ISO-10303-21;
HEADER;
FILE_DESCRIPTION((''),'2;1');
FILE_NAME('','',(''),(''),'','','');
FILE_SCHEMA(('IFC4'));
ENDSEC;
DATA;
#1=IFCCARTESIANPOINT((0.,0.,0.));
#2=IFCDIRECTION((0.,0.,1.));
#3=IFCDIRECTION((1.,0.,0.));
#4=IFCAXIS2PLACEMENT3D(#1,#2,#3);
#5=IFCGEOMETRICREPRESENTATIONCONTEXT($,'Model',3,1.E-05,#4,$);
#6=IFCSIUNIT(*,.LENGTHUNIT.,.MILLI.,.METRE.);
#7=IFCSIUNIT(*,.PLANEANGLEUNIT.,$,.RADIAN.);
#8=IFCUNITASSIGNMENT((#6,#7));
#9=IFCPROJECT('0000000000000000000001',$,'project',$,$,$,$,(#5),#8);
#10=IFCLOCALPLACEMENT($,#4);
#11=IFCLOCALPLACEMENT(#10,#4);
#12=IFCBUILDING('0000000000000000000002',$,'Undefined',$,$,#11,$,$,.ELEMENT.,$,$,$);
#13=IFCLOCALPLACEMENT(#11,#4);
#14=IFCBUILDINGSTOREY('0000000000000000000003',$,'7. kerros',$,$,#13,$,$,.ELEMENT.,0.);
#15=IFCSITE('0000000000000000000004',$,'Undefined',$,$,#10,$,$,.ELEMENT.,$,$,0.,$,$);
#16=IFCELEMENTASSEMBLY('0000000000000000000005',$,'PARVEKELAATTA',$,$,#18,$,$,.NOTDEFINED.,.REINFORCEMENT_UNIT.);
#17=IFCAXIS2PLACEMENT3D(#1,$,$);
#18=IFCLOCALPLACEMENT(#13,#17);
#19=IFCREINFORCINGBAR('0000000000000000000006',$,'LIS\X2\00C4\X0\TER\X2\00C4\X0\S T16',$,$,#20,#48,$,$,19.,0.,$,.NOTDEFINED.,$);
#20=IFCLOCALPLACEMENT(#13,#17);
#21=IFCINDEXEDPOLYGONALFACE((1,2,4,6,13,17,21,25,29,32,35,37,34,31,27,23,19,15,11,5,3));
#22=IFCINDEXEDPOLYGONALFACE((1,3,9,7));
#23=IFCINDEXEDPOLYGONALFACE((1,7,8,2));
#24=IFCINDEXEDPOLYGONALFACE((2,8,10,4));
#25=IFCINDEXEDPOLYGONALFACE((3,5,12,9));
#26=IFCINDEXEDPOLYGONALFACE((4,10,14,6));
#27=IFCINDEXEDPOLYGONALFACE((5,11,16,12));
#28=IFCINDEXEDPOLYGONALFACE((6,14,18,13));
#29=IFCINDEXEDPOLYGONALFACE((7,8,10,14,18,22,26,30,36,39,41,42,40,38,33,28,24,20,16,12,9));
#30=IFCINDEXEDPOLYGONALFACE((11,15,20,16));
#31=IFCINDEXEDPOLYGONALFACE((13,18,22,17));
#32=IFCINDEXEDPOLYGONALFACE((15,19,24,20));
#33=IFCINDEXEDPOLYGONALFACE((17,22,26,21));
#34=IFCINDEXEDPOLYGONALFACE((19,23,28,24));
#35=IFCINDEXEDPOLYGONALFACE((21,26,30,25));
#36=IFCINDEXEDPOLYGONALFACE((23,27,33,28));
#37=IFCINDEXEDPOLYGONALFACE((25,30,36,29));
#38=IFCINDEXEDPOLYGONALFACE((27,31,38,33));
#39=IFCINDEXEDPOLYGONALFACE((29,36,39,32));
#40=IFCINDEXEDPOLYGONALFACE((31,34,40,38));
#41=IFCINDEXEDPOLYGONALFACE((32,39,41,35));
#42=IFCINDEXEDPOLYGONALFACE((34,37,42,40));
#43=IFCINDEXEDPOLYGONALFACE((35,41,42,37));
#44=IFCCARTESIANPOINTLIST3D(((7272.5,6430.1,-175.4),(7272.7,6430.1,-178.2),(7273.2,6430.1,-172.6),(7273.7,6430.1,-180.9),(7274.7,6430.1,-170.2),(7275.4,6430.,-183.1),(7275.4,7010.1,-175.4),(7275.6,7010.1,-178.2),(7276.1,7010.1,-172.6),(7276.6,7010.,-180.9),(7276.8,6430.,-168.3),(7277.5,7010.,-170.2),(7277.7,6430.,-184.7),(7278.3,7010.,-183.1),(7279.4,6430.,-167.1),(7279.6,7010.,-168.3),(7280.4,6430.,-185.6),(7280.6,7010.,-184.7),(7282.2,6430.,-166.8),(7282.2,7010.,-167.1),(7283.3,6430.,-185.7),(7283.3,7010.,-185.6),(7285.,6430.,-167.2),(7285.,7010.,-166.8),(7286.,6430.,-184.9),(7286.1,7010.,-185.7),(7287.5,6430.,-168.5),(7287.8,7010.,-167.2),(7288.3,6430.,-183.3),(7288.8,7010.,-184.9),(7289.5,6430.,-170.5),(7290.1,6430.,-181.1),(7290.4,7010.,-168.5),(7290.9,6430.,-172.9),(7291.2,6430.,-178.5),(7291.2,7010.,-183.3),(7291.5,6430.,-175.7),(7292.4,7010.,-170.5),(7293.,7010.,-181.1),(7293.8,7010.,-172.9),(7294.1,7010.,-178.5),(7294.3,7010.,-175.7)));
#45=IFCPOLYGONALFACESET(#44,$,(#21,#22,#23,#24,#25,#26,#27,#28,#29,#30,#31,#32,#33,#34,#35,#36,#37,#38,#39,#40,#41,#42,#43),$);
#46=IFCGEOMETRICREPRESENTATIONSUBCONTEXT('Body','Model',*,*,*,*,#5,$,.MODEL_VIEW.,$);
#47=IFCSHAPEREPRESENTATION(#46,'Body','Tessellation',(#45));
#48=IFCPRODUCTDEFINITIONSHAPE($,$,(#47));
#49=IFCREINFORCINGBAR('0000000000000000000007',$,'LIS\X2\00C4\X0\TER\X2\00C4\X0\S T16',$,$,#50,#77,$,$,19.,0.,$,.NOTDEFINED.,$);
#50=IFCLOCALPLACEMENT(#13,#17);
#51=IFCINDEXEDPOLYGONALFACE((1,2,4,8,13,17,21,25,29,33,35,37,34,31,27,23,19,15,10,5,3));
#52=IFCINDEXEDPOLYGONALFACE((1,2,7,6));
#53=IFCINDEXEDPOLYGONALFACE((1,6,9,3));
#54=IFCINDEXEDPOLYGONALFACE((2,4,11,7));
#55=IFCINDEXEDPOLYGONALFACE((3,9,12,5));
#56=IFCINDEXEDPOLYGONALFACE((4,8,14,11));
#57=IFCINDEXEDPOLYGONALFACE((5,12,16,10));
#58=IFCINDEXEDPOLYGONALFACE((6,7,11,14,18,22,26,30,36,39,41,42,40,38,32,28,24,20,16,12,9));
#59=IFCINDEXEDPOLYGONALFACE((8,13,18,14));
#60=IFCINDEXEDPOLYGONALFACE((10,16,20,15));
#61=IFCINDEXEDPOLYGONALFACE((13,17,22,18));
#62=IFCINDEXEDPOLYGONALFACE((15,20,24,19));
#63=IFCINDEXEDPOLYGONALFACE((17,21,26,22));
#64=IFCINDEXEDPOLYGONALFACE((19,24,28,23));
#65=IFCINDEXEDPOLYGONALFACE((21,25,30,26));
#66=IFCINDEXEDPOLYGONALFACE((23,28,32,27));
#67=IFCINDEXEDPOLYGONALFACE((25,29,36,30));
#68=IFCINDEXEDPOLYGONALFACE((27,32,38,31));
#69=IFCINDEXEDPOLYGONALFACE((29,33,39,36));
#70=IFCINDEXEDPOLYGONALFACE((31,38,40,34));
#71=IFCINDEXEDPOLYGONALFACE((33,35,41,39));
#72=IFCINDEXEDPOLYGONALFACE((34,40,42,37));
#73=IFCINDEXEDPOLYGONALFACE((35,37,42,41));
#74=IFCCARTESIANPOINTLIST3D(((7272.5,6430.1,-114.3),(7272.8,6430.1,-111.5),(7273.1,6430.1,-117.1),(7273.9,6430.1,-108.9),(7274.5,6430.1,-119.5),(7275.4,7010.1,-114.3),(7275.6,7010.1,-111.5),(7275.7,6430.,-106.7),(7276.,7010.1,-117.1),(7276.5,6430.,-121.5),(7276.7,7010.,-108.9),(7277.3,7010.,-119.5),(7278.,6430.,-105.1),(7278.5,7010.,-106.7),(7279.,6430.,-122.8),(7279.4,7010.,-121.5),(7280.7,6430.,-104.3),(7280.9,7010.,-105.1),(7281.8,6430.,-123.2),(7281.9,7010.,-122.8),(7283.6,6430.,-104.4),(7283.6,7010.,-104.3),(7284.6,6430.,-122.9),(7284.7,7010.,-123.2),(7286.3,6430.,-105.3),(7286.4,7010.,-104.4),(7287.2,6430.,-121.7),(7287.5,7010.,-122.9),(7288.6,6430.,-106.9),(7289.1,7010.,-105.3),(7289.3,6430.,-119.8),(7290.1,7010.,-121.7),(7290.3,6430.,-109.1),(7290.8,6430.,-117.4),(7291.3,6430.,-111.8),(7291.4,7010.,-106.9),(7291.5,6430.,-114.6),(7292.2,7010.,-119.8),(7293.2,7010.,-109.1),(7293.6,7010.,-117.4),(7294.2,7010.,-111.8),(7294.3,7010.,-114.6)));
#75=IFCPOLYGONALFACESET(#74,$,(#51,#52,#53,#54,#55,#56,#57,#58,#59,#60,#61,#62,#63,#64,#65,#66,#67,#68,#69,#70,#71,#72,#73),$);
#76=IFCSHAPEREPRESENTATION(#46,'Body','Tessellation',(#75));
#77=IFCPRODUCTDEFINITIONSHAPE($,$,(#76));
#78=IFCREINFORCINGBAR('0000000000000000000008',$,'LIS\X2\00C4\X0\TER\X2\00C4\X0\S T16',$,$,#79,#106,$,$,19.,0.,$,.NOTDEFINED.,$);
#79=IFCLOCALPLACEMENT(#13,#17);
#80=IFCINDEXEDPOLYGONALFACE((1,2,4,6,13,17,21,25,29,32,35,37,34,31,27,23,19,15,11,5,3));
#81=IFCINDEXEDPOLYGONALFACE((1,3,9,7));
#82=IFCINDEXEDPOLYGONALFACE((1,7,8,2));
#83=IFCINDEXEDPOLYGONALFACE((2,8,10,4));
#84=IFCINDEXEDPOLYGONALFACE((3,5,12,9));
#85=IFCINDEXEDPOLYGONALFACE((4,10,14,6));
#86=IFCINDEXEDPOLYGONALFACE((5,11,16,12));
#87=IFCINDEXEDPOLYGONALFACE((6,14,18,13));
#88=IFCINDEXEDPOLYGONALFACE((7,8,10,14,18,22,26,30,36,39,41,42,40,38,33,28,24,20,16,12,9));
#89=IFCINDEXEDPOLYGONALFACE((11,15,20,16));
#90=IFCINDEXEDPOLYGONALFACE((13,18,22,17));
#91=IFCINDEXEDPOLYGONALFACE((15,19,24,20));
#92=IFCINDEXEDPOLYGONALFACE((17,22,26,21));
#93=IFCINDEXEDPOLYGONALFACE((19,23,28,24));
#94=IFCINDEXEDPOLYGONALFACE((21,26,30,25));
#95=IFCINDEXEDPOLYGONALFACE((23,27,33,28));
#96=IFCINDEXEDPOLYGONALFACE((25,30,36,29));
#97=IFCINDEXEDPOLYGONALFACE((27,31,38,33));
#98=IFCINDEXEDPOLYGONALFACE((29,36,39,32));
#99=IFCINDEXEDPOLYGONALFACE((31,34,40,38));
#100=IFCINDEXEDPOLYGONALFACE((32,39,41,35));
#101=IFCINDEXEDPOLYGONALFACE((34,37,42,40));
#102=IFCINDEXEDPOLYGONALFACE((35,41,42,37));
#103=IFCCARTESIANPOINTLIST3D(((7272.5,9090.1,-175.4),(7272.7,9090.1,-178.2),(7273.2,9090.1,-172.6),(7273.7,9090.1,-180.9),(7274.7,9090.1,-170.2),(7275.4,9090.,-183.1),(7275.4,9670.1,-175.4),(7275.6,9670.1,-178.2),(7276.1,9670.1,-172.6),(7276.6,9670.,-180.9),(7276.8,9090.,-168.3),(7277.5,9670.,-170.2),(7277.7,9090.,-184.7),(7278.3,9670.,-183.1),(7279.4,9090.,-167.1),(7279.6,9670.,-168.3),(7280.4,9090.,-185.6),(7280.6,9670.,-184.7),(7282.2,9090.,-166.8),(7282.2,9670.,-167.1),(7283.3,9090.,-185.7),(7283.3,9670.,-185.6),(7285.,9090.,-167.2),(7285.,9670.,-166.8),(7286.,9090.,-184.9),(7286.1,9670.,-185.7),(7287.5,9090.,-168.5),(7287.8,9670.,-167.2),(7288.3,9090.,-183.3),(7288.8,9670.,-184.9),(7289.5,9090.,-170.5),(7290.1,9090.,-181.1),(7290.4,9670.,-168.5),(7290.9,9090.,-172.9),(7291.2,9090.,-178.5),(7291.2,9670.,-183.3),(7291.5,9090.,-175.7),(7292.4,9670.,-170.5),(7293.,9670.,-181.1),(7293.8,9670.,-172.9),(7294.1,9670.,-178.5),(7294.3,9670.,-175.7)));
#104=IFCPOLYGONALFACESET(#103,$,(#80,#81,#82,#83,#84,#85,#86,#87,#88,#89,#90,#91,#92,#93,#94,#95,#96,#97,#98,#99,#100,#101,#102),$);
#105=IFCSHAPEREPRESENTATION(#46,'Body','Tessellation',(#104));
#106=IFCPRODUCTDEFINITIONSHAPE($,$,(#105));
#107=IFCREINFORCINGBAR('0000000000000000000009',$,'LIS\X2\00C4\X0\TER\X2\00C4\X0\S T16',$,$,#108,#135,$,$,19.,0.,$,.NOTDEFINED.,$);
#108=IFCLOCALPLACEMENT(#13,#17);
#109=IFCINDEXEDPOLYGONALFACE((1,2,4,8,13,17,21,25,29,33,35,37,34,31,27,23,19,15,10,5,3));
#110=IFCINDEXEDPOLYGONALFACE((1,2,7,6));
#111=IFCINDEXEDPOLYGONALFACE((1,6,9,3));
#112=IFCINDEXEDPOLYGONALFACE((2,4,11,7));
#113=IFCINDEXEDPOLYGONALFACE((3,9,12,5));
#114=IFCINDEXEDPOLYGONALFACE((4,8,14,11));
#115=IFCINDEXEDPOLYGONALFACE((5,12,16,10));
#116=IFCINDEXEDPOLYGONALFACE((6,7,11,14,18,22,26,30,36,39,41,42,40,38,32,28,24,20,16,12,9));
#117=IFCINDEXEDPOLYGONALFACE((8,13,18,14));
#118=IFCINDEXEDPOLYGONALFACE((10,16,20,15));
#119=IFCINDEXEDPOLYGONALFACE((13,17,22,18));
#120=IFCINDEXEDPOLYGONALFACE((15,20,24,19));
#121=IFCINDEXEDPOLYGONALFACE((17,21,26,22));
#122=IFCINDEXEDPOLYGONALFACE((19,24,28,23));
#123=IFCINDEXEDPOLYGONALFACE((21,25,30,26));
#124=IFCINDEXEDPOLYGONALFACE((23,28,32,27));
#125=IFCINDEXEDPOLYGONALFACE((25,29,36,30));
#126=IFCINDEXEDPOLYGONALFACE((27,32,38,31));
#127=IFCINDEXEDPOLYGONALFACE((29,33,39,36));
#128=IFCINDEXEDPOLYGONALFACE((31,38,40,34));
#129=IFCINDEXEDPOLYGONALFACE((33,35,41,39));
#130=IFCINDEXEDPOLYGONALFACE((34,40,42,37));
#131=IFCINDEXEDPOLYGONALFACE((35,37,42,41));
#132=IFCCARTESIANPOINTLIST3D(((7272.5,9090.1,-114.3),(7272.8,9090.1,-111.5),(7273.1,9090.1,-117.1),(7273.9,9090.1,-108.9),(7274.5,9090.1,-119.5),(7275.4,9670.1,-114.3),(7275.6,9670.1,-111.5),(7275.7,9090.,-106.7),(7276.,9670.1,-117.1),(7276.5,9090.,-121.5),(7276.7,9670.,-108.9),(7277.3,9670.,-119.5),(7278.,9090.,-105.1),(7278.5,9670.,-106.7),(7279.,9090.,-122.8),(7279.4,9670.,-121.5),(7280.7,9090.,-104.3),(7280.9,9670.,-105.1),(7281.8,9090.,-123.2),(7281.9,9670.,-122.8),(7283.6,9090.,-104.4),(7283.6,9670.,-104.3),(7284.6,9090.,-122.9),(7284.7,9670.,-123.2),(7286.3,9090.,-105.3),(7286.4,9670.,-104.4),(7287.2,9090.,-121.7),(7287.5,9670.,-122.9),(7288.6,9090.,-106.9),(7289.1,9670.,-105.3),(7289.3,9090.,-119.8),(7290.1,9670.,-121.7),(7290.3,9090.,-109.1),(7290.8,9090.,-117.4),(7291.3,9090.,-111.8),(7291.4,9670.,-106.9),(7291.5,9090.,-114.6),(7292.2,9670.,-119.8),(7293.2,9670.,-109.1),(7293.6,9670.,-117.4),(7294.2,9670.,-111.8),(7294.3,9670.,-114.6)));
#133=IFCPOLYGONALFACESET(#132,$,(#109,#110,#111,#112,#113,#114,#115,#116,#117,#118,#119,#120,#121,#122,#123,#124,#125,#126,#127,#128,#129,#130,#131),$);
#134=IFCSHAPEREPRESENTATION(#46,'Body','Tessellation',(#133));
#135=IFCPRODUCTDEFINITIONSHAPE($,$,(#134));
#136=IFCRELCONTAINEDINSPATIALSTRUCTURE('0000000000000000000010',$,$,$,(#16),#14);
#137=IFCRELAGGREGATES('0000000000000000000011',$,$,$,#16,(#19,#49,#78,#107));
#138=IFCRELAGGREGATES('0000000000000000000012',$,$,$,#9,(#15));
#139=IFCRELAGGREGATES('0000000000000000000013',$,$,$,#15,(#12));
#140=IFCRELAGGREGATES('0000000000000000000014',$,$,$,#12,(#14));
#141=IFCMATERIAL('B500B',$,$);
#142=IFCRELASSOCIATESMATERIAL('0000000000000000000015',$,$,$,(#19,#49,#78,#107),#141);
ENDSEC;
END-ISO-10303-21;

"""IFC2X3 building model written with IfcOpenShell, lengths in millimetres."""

from ifc_helpers import new_model, entity, si_unit, frame, origin_with_axes, place, context, subcontext, project, spatial, source, transform, mapped, material, element, aggregate, save


model = new_model("IFC2X3")

# Units and contexts
model_context = context("Model", 3, precision=1e-05, world=origin_with_axes())
body_context = subcontext(model_context, "Body", "Model", "MODEL_VIEW")
ifc_project = project(units=[si_unit("LENGTHUNIT", "METRE", prefix="MILLI"), si_unit("PLANEANGLEUNIT", "RADIAN")], contexts=[model_context])

# Site, building, storey
site_placement = place(None, origin_with_axes())
site = spatial("IfcSite", under=ifc_project, at=site_placement, Name="Undefined", CompositionType="ELEMENT", RefElevation=0.0)
building_placement = place(site_placement, origin_with_axes())
building = spatial("IfcBuilding", under=site, at=building_placement, Name="Undefined", CompositionType="ELEMENT")
storey_placement = place(building_placement, origin_with_axes())
storey = spatial("IfcBuildingStorey", under=building, at=storey_placement, Name="7. kerros", CompositionType="ELEMENT", Elevation=0.0)

# Element assembly, reinforcing bars
assembly_placement = place(storey_placement, origin_with_axes())
assembly = element("IfcElementAssembly", 1, at=assembly_placement, inside=storey, Name="PARVEKELAATTA", AssemblyPlace="NOTDEFINED", PredefinedType="REINFORCEMENT_UNIT")
ifc_material_1 = material(Name="B500B")
shared_shape_1 = source(origin_with_axes(), body_context, "Body", "AdvancedSweptSolid", [
    entity("IfcSweptDiskSolid", entity("IfcTrimmedCurve", entity("IfcLine", entity("IfcCartesianPoint", [0.0, 0.0, 0.0]), entity("IfcVector", entity("IfcDirection", [1.0, 0.0, 0.0]), 1.0)), [entity("IfcParameterValue", 0.0)], [entity("IfcParameterValue", 580.0)], True, "PARAMETER"), 9.5, None, 0.0, 580.0),
])
reinforcing_bar_1_placement = place(assembly_placement, frame((7284.9, 7010.0, -176.2), z_axis=(0.857354, -0.004233, -0.51471), x_axis=(-0.004937, -0.999988, 0.0)))
reinforcing_bar_1 = element("IfcReinforcingBar", 2, at=reinforcing_bar_1_placement, material=ifc_material_1, Name="LISÄTERÄS T16", BarRole="NOTDEFINED", CrossSectionArea=0.0, NominalDiameter=19.0, context=body_context, shape_type="MappedRepresentation", body=[
    mapped(shared_shape_1, transform((0.0, 0.0, 0.0))),
])
shared_shape_2 = source(origin_with_axes(), body_context, "Body", "AdvancedSweptSolid", [
    entity("IfcSweptDiskSolid", entity("IfcTrimmedCurve", entity("IfcLine", entity("IfcCartesianPoint", [0.0, 0.0, 0.0]), entity("IfcVector", entity("IfcDirection", [1.0, 0.0, 0.0]), 1.0)), [entity("IfcParameterValue", 0.0)], [entity("IfcParameterValue", 580.0)], True, "PARAMETER"), 9.5, None, 0.0, 580.0),
])
reinforcing_bar_2_placement = place(assembly_placement, frame((7282.0, 6430.0, -113.7), z_axis=(-0.857354, 0.004233, 0.51471), x_axis=(0.004937, 0.999988, 0.0)))
reinforcing_bar_2 = element("IfcReinforcingBar", 3, at=reinforcing_bar_2_placement, material=ifc_material_1, Name="LISÄTERÄS T16", BarRole="NOTDEFINED", CrossSectionArea=0.0, NominalDiameter=19.0, context=body_context, shape_type="MappedRepresentation", body=[
    mapped(shared_shape_2, transform((0.0, 0.0, 0.0))),
])
shared_shape_3 = source(origin_with_axes(), body_context, "Body", "AdvancedSweptSolid", [
    entity("IfcSweptDiskSolid", entity("IfcTrimmedCurve", entity("IfcLine", entity("IfcCartesianPoint", [0.0, 0.0, 0.0]), entity("IfcVector", entity("IfcDirection", [1.0, 0.0, 0.0]), 1.0)), [entity("IfcParameterValue", 0.0)], [entity("IfcParameterValue", 580.0)], True, "PARAMETER"), 9.5, None, 0.0, 580.0),
])
reinforcing_bar_3_placement = place(assembly_placement, frame((7284.9, 9670.0, -176.2), z_axis=(0.857354, -0.004233, -0.51471), x_axis=(-0.004937, -0.999988, 0.0)))
reinforcing_bar_3 = element("IfcReinforcingBar", 4, at=reinforcing_bar_3_placement, material=ifc_material_1, Name="LISÄTERÄS T16", BarRole="NOTDEFINED", CrossSectionArea=0.0, NominalDiameter=19.0, context=body_context, shape_type="MappedRepresentation", body=[
    mapped(shared_shape_3, transform((0.0, 0.0, 0.0))),
])
shared_shape_4 = source(origin_with_axes(), body_context, "Body", "AdvancedSweptSolid", [
    entity("IfcSweptDiskSolid", entity("IfcTrimmedCurve", entity("IfcLine", entity("IfcCartesianPoint", [0.0, 0.0, 0.0]), entity("IfcVector", entity("IfcDirection", [1.0, 0.0, 0.0]), 1.0)), [entity("IfcParameterValue", 0.0)], [entity("IfcParameterValue", 580.0)], True, "PARAMETER"), 9.5, None, 0.0, 580.0),
])
reinforcing_bar_4_placement = place(assembly_placement, frame((7282.0, 9090.0, -113.7), z_axis=(-0.857354, 0.004233, 0.51471), x_axis=(0.004937, 0.999988, 0.0)))
reinforcing_bar_4 = element("IfcReinforcingBar", 5, at=reinforcing_bar_4_placement, material=ifc_material_1, Name="LISÄTERÄS T16", BarRole="NOTDEFINED", CrossSectionArea=0.0, NominalDiameter=19.0, context=body_context, shape_type="MappedRepresentation", body=[
    mapped(shared_shape_4, transform((0.0, 0.0, 0.0))),
])
aggregate(assembly, [reinforcing_bar_1, reinforcing_bar_2, reinforcing_bar_3, reinforcing_bar_4])

save(model, "model.ifc")
